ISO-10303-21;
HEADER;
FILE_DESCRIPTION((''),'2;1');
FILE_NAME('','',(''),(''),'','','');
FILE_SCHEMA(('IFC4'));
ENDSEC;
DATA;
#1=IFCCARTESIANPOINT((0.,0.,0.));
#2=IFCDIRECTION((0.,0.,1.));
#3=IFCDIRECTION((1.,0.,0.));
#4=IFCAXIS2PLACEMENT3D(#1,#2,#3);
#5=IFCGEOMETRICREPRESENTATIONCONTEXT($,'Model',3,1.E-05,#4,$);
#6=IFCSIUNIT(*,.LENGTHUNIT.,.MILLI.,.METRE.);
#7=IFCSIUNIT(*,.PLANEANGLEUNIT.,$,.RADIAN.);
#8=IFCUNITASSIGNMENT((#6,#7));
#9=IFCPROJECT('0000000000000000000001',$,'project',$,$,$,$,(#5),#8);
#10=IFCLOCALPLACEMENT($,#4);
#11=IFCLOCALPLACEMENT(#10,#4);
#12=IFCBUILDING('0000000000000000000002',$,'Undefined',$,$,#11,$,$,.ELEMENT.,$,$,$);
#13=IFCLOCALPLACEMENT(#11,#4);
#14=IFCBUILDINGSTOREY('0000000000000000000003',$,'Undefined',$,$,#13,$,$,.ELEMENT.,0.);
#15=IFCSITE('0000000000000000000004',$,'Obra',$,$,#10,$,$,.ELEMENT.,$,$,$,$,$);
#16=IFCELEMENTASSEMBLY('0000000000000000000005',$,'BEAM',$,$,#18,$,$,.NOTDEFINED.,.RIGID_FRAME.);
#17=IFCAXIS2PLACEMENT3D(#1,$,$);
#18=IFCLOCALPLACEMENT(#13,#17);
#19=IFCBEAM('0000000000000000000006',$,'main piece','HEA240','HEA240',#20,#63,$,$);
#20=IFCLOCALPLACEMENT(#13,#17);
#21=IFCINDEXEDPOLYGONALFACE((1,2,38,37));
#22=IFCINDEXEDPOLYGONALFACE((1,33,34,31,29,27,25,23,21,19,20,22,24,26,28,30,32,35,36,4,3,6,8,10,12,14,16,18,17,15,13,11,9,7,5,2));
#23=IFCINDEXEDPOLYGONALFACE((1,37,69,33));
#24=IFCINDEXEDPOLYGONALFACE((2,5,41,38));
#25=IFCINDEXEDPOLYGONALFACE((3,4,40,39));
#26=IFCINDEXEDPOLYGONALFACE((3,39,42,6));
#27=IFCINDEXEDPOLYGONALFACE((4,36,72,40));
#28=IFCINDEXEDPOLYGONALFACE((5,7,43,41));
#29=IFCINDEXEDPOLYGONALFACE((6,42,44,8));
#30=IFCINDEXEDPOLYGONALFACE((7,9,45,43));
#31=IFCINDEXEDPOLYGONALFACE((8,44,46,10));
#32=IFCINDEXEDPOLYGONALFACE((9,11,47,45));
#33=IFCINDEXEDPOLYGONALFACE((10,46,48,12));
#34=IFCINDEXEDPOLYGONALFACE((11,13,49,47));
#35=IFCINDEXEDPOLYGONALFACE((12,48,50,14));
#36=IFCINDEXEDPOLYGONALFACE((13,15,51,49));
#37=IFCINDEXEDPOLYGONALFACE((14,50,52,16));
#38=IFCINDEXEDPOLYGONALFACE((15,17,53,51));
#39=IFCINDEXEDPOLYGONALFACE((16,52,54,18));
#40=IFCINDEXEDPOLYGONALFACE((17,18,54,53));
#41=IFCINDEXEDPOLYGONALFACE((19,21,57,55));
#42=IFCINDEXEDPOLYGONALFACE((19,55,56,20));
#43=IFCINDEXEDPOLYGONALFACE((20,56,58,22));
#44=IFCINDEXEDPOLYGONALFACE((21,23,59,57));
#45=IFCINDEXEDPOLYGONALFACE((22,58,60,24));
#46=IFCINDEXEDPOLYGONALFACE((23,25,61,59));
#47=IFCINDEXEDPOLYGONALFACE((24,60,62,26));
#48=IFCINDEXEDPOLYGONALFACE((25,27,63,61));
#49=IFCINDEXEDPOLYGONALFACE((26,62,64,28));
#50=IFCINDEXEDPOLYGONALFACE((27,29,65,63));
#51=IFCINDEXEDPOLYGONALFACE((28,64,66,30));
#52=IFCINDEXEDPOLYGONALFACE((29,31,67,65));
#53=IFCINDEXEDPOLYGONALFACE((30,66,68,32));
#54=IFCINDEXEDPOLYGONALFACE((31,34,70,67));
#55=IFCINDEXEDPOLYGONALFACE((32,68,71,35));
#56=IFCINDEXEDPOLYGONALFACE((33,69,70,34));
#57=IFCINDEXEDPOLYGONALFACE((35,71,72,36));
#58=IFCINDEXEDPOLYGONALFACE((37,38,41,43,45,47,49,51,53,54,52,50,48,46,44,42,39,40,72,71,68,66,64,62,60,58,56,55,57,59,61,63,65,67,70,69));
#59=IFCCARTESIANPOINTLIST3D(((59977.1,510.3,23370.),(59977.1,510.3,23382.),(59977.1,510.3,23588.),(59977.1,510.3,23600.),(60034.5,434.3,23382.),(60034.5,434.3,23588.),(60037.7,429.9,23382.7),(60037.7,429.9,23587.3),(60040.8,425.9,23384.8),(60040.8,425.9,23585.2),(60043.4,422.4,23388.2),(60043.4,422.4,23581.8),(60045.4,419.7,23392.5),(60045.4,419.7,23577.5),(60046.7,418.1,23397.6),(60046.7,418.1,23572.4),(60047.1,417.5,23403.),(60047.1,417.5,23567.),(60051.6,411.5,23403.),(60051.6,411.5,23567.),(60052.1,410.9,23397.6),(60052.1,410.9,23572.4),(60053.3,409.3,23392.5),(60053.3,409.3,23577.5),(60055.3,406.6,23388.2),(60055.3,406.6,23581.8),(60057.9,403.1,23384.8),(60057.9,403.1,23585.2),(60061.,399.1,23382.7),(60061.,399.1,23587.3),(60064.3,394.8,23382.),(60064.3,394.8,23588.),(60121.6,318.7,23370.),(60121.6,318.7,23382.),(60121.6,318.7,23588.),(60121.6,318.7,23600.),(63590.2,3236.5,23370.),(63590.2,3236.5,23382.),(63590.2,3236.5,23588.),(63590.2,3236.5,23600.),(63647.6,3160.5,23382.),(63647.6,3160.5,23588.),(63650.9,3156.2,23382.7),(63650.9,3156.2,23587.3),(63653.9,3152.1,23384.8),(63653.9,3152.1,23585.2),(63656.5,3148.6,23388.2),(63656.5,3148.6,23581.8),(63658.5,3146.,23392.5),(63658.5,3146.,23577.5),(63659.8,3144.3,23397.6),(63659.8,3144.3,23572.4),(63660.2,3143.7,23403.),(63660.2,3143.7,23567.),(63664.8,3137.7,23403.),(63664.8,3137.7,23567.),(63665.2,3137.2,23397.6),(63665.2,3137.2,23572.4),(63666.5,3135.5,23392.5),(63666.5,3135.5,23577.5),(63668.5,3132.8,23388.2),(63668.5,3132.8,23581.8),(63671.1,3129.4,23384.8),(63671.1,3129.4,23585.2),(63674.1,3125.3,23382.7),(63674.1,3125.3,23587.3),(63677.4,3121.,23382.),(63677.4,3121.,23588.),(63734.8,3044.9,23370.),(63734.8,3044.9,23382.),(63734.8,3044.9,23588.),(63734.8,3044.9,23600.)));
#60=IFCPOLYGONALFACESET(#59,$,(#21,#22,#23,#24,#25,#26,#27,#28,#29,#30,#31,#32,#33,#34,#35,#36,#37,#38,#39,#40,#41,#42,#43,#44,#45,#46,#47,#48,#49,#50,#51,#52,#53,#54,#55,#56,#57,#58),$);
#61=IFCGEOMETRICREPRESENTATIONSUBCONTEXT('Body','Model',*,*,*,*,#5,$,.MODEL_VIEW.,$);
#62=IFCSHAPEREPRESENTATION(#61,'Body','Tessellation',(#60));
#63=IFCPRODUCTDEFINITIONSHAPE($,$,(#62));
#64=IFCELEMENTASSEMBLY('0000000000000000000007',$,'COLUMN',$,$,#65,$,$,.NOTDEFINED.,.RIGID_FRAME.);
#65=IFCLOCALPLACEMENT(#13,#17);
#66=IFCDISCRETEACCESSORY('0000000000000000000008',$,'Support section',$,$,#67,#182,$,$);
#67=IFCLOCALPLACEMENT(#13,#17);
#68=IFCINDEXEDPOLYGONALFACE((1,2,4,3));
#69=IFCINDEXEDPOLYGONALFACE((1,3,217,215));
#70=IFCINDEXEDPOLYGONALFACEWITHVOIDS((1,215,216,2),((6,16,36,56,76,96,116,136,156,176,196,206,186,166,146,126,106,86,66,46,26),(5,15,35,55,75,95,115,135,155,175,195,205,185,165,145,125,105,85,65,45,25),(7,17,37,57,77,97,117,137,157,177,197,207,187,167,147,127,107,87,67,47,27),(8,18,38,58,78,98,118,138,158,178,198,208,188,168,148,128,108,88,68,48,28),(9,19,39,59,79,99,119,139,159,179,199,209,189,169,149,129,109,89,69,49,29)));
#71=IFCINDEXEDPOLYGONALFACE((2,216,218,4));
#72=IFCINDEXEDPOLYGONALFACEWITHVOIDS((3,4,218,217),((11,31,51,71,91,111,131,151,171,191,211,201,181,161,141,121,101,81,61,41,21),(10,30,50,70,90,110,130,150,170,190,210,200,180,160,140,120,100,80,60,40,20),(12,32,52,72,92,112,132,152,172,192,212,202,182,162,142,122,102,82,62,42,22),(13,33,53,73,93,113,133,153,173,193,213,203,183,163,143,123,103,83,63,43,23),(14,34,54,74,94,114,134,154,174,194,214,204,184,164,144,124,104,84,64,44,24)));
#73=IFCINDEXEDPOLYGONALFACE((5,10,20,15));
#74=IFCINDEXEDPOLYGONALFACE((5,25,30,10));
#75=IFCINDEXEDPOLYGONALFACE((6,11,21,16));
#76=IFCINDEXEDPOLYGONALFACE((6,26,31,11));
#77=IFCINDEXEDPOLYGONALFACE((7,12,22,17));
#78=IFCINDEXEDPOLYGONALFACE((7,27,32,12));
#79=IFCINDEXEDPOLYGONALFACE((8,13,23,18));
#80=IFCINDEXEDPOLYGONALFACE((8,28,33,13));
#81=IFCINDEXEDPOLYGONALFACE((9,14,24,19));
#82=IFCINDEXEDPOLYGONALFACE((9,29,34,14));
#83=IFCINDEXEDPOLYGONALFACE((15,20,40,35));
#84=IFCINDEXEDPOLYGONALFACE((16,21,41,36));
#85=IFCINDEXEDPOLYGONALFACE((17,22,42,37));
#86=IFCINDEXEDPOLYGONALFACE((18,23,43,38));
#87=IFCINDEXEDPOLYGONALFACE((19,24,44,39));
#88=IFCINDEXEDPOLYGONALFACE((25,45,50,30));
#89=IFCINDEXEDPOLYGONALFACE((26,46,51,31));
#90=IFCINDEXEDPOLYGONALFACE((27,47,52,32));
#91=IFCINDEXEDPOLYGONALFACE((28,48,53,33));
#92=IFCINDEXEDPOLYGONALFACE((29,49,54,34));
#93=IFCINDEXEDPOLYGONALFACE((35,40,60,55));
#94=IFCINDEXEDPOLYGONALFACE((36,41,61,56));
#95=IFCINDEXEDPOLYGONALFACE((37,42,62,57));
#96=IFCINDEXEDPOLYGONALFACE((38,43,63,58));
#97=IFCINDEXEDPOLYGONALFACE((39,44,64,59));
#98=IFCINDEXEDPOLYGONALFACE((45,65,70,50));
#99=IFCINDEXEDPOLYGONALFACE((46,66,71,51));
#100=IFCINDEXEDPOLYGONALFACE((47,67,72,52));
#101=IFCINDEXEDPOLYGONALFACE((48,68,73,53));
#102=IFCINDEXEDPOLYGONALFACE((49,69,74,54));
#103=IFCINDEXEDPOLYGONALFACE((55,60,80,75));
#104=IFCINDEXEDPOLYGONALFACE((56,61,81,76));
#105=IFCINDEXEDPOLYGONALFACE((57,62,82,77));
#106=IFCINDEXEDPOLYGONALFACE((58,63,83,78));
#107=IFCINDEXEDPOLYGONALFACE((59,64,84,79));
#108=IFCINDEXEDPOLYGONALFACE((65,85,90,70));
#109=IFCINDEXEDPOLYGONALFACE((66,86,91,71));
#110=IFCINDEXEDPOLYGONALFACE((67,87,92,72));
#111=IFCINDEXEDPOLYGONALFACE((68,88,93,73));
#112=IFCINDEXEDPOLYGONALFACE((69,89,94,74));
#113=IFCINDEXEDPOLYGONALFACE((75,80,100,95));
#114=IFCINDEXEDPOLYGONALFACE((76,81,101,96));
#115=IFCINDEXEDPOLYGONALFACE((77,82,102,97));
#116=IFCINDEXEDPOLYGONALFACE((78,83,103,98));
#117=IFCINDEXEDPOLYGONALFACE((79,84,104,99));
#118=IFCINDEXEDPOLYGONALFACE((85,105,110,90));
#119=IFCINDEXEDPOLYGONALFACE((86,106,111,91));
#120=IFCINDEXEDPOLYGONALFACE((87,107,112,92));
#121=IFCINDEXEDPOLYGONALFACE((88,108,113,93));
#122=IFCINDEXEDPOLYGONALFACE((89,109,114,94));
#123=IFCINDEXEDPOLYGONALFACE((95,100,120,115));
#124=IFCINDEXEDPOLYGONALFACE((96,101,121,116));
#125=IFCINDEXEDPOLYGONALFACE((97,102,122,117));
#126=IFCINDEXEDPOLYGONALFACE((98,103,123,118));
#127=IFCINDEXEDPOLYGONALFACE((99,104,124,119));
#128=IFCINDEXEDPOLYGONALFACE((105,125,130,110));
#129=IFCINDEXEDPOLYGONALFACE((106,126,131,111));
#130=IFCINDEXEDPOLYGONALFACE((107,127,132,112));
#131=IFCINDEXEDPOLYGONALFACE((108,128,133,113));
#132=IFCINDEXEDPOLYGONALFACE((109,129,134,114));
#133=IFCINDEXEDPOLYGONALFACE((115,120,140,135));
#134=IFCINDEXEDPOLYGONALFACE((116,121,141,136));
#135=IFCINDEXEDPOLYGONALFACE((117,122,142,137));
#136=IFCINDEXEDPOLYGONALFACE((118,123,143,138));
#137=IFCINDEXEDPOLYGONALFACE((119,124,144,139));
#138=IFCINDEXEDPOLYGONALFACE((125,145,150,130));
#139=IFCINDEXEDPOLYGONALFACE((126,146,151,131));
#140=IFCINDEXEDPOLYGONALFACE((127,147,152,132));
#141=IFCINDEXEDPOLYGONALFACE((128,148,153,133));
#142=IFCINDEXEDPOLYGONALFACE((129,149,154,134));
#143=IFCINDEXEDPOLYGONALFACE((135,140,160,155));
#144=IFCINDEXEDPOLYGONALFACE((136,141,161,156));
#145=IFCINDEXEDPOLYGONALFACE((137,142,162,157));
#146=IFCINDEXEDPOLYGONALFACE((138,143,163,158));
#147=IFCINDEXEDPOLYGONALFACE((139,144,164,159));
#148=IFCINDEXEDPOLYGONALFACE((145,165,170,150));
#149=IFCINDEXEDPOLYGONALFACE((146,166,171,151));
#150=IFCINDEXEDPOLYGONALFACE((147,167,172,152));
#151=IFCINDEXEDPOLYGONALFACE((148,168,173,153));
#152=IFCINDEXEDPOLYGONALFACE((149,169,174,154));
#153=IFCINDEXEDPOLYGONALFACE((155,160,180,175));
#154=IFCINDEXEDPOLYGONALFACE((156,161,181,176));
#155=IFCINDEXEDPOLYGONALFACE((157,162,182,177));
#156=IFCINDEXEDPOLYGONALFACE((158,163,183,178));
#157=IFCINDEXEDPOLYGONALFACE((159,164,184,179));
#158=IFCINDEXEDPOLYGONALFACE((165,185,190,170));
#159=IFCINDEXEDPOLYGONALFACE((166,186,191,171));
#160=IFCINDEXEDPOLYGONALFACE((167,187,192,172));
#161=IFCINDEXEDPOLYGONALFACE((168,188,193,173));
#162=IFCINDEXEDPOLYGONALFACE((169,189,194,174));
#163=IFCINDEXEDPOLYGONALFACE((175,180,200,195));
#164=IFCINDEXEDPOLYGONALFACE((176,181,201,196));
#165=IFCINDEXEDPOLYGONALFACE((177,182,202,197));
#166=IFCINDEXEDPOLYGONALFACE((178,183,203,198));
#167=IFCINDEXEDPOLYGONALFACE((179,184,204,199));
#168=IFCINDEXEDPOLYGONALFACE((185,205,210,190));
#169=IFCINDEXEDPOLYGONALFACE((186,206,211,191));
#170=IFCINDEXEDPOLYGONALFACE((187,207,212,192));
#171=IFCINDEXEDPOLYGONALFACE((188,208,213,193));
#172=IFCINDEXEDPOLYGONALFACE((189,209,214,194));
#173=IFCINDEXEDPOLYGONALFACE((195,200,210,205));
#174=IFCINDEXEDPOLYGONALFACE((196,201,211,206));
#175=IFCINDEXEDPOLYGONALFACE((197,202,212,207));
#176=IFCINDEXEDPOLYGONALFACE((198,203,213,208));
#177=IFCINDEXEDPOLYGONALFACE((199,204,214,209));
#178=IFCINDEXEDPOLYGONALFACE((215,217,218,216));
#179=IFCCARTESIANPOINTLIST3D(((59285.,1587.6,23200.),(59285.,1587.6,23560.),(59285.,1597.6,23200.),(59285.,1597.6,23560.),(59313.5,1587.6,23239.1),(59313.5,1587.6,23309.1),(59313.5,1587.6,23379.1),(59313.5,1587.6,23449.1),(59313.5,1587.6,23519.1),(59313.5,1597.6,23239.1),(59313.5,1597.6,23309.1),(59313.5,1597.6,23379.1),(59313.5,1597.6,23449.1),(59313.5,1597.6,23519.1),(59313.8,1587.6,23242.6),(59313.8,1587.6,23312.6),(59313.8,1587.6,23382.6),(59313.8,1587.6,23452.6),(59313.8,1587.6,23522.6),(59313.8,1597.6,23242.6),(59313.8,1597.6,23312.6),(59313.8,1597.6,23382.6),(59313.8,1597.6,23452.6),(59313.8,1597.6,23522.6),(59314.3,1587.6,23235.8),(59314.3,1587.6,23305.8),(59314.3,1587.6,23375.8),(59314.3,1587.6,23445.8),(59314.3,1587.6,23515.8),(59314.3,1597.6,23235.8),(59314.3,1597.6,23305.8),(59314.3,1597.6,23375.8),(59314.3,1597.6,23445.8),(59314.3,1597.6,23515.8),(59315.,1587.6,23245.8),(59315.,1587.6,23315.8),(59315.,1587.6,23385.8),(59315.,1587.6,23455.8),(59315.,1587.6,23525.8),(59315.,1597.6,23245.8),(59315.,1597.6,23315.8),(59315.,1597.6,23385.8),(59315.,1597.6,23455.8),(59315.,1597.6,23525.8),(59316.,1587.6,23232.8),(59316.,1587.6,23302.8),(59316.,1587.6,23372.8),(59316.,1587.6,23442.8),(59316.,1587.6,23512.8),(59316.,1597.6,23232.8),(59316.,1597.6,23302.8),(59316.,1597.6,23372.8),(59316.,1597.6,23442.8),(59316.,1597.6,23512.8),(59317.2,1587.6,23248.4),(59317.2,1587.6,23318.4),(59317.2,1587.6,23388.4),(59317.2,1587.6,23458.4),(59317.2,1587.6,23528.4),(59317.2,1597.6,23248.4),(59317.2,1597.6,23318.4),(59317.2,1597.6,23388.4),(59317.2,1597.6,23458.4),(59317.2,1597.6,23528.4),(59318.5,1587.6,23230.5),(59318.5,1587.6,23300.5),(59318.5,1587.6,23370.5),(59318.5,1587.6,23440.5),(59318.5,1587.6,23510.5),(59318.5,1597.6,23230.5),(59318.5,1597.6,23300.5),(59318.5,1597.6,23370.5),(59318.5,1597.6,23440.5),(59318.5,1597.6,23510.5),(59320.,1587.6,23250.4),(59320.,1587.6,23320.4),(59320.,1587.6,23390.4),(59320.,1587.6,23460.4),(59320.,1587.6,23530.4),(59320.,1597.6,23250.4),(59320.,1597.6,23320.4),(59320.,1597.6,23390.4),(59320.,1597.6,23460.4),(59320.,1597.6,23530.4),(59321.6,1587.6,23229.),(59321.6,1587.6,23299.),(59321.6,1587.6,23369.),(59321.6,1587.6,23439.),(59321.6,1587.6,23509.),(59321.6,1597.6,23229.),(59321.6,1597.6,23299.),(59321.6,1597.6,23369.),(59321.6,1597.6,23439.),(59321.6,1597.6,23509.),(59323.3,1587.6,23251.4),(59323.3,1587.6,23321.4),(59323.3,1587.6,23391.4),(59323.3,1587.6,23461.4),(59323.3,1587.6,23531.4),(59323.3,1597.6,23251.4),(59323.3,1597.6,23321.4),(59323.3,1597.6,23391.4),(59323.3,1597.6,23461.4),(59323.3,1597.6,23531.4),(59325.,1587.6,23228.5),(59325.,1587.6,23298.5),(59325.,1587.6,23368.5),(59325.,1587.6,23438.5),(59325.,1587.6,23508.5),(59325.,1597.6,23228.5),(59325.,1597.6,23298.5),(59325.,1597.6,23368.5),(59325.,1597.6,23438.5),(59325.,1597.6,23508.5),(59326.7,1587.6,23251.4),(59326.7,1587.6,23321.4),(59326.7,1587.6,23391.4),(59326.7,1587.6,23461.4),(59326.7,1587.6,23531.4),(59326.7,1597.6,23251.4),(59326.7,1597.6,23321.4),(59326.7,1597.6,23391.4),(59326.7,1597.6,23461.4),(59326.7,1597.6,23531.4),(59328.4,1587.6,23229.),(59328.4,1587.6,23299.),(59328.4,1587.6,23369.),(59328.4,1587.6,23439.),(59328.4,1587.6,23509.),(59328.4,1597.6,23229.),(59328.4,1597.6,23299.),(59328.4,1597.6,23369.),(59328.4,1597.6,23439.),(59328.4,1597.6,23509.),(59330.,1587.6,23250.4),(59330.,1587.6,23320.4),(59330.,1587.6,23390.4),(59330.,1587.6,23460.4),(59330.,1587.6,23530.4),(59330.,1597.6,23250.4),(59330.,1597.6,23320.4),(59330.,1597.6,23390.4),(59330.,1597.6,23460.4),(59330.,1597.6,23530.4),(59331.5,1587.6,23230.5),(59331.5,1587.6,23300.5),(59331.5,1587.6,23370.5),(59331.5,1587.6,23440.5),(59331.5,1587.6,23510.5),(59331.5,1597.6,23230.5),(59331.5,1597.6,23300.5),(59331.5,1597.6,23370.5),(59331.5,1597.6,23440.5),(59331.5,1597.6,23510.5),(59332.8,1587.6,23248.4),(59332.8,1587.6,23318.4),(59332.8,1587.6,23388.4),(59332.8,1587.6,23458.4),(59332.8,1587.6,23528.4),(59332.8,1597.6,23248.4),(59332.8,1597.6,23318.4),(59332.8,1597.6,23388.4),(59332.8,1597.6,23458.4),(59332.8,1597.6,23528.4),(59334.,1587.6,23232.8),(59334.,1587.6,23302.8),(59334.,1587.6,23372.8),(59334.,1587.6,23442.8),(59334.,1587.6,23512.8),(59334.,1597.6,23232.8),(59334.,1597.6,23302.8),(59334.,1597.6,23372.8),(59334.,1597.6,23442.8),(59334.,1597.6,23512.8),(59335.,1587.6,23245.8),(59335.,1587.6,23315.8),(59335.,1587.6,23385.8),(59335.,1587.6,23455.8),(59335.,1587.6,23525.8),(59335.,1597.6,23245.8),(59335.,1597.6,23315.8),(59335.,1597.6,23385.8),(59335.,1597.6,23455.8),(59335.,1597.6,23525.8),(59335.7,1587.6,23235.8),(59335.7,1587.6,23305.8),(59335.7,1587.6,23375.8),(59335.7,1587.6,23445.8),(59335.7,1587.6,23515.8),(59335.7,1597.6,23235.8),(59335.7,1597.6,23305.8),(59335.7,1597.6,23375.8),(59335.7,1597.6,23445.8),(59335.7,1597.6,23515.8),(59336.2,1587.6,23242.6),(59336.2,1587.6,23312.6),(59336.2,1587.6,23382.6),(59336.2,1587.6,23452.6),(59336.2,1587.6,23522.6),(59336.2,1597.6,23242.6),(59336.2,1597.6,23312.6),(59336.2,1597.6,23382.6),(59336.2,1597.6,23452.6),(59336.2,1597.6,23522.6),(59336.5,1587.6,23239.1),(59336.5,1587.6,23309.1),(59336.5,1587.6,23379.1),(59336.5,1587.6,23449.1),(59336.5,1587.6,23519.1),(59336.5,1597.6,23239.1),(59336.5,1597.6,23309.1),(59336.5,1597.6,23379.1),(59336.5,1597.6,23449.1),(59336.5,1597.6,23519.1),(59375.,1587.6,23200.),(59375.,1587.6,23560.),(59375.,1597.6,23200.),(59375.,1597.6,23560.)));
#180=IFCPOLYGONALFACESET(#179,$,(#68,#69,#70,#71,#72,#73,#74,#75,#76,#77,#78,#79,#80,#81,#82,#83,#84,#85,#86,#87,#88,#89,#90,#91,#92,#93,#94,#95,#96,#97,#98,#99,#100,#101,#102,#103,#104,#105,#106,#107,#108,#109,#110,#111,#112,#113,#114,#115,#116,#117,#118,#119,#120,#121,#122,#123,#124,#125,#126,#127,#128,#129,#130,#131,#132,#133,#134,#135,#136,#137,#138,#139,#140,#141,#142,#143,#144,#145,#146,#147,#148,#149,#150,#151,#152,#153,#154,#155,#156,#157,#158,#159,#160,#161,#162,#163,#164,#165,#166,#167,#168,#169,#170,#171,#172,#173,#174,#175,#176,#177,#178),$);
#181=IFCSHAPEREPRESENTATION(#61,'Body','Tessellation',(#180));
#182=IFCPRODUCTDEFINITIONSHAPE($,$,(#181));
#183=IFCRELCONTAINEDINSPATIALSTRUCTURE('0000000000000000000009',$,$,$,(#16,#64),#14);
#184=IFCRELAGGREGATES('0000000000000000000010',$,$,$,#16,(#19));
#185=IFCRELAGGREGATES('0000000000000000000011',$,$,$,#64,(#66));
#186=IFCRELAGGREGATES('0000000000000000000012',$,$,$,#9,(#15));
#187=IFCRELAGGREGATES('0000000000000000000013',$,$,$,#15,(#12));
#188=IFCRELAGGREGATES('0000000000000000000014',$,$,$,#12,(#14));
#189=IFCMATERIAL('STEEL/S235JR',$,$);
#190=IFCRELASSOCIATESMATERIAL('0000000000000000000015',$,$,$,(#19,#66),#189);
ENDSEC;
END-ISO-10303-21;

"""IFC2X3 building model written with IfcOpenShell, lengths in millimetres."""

from ifc_helpers import new_model, si_unit, frame, origin_with_axes, origin_2d_with_axis, place, context, subcontext, project, spatial, rectangle, circle, i_section, extrude, source, transform, mapped, material, element, aggregate, save


model = new_model("IFC2X3")

# Units and contexts
model_context = context("Model", 3, precision=1e-05, world=origin_with_axes())
body_context = subcontext(model_context, "Body", "Model", "MODEL_VIEW")
ifc_project = project(units=[si_unit("LENGTHUNIT", "METRE", prefix="MILLI"), si_unit("PLANEANGLEUNIT", "RADIAN")], contexts=[model_context])

# Site, building, storey
site_placement = place(None, origin_with_axes())
site = spatial("IfcSite", under=ifc_project, at=site_placement, Name="Obra", CompositionType="ELEMENT")
building_placement = place(site_placement, origin_with_axes())
building = spatial("IfcBuilding", under=site, at=building_placement, Name="Undefined", CompositionType="ELEMENT")
storey_placement = place(building_placement, origin_with_axes())
storey = spatial("IfcBuildingStorey", under=building, at=storey_placement, Name="Undefined", CompositionType="ELEMENT", Elevation=0.0)

# Shared definitions
ifc_material_1 = material(Name="STEEL/S235JR")

# Element assembly, beam
assembly_1_placement = place(storey_placement, origin_with_axes())
assembly_1 = element("IfcElementAssembly", 1, at=assembly_1_placement, inside=storey, Name="BEAM", AssemblyPlace="NOTDEFINED", PredefinedType="RIGID_FRAME")
beam_1_placement = place(assembly_1_placement, frame((60049.4, 414.5, 23485.0), z_axis=(0.0, 0.0, 1.0), x_axis=(0.79826, 0.602313, 0.0)))
beam_1 = element("IfcBeam", 2, at=beam_1_placement, material=ifc_material_1, Name="main piece", Description="HEA240", ObjectType="HEA240", context=body_context, shape_type="SweptSolid", body=[
    extrude(i_section(OverallWidth=240.0, OverallDepth=230.0, WebThickness=7.5, FlangeThickness=12.0, FilletRadius=21.0, at=origin_2d_with_axis()), frame((4526.3, 0.0, 0.0), z_axis=(-1.0, 0.0, 0.0), x_axis=(0.0, -1.0, 0.0)), (0.0, 0.0, 1.0), 4526.3),
])
aggregate(assembly_1, [beam_1])

# Element assembly, discrete accessory, opening
assembly_2_placement = place(storey_placement, origin_with_axes())
assembly_2 = element("IfcElementAssembly", 3, at=assembly_2_placement, inside=storey, Name="COLUMN", AssemblyPlace="NOTDEFINED", PredefinedType="RIGID_FRAME")
discrete_accessory_1_placement = place(assembly_2_placement, frame((59330.0, 1592.6, 23200.0), z_axis=(0.0, 0.0, 1.0), x_axis=(1.0, 0.0, 0.0)))
discrete_accessory_1 = element("IfcDiscreteAccessory", 4, at=discrete_accessory_1_placement, material=ifc_material_1, Name="Support section", context=body_context, shape_type="SweptSolid", body=[
    extrude(rectangle(XDim=10.0, YDim=90.0, at=origin_2d_with_axis()), frame((0.0, 0.0, 360.0), z_axis=(0.0, 0.0, -1.0), x_axis=(0.0, 1.0, 0.0)), (0.0, 0.0, 1.0), 360.0),
])
shared_shape_1 = source(origin_with_axes(), body_context, "Body", "SweptSolid", [
    extrude(circle(Radius=11.5, at=origin_2d_with_axis()), frame((0.0, 5.7, 0.0), z_axis=(0.0, 1.0, 0.0), x_axis=(1.0, 0.0, 0.0)), (0.0, 0.0, 1.0), 10.2),
])
opening_1_placement = place(assembly_2_placement, frame((59365.0, 1603.4, 23600.0), z_axis=(-1.0, 0.0, 0.0), x_axis=(0.0, 0.0, -1.0)))
element("IfcOpeningElement", 5, at=opening_1_placement, cuts=discrete_accessory_1, ObjectType="Opening", context=body_context, shape_type="MappedRepresentation", body=[
    mapped(shared_shape_1, transform((80.0, 0.0, 40.0))),
    mapped(shared_shape_1, transform((150.0, 0.0, 40.0))),
    mapped(shared_shape_1, transform((220.0, 0.0, 40.0))),
    mapped(shared_shape_1, transform((290.0, 0.0, 40.0))),
    mapped(shared_shape_1, transform((360.0, 0.0, 40.0))),
])

aggregate(assembly_2, [discrete_accessory_1])

save(model, "model.ifc")
